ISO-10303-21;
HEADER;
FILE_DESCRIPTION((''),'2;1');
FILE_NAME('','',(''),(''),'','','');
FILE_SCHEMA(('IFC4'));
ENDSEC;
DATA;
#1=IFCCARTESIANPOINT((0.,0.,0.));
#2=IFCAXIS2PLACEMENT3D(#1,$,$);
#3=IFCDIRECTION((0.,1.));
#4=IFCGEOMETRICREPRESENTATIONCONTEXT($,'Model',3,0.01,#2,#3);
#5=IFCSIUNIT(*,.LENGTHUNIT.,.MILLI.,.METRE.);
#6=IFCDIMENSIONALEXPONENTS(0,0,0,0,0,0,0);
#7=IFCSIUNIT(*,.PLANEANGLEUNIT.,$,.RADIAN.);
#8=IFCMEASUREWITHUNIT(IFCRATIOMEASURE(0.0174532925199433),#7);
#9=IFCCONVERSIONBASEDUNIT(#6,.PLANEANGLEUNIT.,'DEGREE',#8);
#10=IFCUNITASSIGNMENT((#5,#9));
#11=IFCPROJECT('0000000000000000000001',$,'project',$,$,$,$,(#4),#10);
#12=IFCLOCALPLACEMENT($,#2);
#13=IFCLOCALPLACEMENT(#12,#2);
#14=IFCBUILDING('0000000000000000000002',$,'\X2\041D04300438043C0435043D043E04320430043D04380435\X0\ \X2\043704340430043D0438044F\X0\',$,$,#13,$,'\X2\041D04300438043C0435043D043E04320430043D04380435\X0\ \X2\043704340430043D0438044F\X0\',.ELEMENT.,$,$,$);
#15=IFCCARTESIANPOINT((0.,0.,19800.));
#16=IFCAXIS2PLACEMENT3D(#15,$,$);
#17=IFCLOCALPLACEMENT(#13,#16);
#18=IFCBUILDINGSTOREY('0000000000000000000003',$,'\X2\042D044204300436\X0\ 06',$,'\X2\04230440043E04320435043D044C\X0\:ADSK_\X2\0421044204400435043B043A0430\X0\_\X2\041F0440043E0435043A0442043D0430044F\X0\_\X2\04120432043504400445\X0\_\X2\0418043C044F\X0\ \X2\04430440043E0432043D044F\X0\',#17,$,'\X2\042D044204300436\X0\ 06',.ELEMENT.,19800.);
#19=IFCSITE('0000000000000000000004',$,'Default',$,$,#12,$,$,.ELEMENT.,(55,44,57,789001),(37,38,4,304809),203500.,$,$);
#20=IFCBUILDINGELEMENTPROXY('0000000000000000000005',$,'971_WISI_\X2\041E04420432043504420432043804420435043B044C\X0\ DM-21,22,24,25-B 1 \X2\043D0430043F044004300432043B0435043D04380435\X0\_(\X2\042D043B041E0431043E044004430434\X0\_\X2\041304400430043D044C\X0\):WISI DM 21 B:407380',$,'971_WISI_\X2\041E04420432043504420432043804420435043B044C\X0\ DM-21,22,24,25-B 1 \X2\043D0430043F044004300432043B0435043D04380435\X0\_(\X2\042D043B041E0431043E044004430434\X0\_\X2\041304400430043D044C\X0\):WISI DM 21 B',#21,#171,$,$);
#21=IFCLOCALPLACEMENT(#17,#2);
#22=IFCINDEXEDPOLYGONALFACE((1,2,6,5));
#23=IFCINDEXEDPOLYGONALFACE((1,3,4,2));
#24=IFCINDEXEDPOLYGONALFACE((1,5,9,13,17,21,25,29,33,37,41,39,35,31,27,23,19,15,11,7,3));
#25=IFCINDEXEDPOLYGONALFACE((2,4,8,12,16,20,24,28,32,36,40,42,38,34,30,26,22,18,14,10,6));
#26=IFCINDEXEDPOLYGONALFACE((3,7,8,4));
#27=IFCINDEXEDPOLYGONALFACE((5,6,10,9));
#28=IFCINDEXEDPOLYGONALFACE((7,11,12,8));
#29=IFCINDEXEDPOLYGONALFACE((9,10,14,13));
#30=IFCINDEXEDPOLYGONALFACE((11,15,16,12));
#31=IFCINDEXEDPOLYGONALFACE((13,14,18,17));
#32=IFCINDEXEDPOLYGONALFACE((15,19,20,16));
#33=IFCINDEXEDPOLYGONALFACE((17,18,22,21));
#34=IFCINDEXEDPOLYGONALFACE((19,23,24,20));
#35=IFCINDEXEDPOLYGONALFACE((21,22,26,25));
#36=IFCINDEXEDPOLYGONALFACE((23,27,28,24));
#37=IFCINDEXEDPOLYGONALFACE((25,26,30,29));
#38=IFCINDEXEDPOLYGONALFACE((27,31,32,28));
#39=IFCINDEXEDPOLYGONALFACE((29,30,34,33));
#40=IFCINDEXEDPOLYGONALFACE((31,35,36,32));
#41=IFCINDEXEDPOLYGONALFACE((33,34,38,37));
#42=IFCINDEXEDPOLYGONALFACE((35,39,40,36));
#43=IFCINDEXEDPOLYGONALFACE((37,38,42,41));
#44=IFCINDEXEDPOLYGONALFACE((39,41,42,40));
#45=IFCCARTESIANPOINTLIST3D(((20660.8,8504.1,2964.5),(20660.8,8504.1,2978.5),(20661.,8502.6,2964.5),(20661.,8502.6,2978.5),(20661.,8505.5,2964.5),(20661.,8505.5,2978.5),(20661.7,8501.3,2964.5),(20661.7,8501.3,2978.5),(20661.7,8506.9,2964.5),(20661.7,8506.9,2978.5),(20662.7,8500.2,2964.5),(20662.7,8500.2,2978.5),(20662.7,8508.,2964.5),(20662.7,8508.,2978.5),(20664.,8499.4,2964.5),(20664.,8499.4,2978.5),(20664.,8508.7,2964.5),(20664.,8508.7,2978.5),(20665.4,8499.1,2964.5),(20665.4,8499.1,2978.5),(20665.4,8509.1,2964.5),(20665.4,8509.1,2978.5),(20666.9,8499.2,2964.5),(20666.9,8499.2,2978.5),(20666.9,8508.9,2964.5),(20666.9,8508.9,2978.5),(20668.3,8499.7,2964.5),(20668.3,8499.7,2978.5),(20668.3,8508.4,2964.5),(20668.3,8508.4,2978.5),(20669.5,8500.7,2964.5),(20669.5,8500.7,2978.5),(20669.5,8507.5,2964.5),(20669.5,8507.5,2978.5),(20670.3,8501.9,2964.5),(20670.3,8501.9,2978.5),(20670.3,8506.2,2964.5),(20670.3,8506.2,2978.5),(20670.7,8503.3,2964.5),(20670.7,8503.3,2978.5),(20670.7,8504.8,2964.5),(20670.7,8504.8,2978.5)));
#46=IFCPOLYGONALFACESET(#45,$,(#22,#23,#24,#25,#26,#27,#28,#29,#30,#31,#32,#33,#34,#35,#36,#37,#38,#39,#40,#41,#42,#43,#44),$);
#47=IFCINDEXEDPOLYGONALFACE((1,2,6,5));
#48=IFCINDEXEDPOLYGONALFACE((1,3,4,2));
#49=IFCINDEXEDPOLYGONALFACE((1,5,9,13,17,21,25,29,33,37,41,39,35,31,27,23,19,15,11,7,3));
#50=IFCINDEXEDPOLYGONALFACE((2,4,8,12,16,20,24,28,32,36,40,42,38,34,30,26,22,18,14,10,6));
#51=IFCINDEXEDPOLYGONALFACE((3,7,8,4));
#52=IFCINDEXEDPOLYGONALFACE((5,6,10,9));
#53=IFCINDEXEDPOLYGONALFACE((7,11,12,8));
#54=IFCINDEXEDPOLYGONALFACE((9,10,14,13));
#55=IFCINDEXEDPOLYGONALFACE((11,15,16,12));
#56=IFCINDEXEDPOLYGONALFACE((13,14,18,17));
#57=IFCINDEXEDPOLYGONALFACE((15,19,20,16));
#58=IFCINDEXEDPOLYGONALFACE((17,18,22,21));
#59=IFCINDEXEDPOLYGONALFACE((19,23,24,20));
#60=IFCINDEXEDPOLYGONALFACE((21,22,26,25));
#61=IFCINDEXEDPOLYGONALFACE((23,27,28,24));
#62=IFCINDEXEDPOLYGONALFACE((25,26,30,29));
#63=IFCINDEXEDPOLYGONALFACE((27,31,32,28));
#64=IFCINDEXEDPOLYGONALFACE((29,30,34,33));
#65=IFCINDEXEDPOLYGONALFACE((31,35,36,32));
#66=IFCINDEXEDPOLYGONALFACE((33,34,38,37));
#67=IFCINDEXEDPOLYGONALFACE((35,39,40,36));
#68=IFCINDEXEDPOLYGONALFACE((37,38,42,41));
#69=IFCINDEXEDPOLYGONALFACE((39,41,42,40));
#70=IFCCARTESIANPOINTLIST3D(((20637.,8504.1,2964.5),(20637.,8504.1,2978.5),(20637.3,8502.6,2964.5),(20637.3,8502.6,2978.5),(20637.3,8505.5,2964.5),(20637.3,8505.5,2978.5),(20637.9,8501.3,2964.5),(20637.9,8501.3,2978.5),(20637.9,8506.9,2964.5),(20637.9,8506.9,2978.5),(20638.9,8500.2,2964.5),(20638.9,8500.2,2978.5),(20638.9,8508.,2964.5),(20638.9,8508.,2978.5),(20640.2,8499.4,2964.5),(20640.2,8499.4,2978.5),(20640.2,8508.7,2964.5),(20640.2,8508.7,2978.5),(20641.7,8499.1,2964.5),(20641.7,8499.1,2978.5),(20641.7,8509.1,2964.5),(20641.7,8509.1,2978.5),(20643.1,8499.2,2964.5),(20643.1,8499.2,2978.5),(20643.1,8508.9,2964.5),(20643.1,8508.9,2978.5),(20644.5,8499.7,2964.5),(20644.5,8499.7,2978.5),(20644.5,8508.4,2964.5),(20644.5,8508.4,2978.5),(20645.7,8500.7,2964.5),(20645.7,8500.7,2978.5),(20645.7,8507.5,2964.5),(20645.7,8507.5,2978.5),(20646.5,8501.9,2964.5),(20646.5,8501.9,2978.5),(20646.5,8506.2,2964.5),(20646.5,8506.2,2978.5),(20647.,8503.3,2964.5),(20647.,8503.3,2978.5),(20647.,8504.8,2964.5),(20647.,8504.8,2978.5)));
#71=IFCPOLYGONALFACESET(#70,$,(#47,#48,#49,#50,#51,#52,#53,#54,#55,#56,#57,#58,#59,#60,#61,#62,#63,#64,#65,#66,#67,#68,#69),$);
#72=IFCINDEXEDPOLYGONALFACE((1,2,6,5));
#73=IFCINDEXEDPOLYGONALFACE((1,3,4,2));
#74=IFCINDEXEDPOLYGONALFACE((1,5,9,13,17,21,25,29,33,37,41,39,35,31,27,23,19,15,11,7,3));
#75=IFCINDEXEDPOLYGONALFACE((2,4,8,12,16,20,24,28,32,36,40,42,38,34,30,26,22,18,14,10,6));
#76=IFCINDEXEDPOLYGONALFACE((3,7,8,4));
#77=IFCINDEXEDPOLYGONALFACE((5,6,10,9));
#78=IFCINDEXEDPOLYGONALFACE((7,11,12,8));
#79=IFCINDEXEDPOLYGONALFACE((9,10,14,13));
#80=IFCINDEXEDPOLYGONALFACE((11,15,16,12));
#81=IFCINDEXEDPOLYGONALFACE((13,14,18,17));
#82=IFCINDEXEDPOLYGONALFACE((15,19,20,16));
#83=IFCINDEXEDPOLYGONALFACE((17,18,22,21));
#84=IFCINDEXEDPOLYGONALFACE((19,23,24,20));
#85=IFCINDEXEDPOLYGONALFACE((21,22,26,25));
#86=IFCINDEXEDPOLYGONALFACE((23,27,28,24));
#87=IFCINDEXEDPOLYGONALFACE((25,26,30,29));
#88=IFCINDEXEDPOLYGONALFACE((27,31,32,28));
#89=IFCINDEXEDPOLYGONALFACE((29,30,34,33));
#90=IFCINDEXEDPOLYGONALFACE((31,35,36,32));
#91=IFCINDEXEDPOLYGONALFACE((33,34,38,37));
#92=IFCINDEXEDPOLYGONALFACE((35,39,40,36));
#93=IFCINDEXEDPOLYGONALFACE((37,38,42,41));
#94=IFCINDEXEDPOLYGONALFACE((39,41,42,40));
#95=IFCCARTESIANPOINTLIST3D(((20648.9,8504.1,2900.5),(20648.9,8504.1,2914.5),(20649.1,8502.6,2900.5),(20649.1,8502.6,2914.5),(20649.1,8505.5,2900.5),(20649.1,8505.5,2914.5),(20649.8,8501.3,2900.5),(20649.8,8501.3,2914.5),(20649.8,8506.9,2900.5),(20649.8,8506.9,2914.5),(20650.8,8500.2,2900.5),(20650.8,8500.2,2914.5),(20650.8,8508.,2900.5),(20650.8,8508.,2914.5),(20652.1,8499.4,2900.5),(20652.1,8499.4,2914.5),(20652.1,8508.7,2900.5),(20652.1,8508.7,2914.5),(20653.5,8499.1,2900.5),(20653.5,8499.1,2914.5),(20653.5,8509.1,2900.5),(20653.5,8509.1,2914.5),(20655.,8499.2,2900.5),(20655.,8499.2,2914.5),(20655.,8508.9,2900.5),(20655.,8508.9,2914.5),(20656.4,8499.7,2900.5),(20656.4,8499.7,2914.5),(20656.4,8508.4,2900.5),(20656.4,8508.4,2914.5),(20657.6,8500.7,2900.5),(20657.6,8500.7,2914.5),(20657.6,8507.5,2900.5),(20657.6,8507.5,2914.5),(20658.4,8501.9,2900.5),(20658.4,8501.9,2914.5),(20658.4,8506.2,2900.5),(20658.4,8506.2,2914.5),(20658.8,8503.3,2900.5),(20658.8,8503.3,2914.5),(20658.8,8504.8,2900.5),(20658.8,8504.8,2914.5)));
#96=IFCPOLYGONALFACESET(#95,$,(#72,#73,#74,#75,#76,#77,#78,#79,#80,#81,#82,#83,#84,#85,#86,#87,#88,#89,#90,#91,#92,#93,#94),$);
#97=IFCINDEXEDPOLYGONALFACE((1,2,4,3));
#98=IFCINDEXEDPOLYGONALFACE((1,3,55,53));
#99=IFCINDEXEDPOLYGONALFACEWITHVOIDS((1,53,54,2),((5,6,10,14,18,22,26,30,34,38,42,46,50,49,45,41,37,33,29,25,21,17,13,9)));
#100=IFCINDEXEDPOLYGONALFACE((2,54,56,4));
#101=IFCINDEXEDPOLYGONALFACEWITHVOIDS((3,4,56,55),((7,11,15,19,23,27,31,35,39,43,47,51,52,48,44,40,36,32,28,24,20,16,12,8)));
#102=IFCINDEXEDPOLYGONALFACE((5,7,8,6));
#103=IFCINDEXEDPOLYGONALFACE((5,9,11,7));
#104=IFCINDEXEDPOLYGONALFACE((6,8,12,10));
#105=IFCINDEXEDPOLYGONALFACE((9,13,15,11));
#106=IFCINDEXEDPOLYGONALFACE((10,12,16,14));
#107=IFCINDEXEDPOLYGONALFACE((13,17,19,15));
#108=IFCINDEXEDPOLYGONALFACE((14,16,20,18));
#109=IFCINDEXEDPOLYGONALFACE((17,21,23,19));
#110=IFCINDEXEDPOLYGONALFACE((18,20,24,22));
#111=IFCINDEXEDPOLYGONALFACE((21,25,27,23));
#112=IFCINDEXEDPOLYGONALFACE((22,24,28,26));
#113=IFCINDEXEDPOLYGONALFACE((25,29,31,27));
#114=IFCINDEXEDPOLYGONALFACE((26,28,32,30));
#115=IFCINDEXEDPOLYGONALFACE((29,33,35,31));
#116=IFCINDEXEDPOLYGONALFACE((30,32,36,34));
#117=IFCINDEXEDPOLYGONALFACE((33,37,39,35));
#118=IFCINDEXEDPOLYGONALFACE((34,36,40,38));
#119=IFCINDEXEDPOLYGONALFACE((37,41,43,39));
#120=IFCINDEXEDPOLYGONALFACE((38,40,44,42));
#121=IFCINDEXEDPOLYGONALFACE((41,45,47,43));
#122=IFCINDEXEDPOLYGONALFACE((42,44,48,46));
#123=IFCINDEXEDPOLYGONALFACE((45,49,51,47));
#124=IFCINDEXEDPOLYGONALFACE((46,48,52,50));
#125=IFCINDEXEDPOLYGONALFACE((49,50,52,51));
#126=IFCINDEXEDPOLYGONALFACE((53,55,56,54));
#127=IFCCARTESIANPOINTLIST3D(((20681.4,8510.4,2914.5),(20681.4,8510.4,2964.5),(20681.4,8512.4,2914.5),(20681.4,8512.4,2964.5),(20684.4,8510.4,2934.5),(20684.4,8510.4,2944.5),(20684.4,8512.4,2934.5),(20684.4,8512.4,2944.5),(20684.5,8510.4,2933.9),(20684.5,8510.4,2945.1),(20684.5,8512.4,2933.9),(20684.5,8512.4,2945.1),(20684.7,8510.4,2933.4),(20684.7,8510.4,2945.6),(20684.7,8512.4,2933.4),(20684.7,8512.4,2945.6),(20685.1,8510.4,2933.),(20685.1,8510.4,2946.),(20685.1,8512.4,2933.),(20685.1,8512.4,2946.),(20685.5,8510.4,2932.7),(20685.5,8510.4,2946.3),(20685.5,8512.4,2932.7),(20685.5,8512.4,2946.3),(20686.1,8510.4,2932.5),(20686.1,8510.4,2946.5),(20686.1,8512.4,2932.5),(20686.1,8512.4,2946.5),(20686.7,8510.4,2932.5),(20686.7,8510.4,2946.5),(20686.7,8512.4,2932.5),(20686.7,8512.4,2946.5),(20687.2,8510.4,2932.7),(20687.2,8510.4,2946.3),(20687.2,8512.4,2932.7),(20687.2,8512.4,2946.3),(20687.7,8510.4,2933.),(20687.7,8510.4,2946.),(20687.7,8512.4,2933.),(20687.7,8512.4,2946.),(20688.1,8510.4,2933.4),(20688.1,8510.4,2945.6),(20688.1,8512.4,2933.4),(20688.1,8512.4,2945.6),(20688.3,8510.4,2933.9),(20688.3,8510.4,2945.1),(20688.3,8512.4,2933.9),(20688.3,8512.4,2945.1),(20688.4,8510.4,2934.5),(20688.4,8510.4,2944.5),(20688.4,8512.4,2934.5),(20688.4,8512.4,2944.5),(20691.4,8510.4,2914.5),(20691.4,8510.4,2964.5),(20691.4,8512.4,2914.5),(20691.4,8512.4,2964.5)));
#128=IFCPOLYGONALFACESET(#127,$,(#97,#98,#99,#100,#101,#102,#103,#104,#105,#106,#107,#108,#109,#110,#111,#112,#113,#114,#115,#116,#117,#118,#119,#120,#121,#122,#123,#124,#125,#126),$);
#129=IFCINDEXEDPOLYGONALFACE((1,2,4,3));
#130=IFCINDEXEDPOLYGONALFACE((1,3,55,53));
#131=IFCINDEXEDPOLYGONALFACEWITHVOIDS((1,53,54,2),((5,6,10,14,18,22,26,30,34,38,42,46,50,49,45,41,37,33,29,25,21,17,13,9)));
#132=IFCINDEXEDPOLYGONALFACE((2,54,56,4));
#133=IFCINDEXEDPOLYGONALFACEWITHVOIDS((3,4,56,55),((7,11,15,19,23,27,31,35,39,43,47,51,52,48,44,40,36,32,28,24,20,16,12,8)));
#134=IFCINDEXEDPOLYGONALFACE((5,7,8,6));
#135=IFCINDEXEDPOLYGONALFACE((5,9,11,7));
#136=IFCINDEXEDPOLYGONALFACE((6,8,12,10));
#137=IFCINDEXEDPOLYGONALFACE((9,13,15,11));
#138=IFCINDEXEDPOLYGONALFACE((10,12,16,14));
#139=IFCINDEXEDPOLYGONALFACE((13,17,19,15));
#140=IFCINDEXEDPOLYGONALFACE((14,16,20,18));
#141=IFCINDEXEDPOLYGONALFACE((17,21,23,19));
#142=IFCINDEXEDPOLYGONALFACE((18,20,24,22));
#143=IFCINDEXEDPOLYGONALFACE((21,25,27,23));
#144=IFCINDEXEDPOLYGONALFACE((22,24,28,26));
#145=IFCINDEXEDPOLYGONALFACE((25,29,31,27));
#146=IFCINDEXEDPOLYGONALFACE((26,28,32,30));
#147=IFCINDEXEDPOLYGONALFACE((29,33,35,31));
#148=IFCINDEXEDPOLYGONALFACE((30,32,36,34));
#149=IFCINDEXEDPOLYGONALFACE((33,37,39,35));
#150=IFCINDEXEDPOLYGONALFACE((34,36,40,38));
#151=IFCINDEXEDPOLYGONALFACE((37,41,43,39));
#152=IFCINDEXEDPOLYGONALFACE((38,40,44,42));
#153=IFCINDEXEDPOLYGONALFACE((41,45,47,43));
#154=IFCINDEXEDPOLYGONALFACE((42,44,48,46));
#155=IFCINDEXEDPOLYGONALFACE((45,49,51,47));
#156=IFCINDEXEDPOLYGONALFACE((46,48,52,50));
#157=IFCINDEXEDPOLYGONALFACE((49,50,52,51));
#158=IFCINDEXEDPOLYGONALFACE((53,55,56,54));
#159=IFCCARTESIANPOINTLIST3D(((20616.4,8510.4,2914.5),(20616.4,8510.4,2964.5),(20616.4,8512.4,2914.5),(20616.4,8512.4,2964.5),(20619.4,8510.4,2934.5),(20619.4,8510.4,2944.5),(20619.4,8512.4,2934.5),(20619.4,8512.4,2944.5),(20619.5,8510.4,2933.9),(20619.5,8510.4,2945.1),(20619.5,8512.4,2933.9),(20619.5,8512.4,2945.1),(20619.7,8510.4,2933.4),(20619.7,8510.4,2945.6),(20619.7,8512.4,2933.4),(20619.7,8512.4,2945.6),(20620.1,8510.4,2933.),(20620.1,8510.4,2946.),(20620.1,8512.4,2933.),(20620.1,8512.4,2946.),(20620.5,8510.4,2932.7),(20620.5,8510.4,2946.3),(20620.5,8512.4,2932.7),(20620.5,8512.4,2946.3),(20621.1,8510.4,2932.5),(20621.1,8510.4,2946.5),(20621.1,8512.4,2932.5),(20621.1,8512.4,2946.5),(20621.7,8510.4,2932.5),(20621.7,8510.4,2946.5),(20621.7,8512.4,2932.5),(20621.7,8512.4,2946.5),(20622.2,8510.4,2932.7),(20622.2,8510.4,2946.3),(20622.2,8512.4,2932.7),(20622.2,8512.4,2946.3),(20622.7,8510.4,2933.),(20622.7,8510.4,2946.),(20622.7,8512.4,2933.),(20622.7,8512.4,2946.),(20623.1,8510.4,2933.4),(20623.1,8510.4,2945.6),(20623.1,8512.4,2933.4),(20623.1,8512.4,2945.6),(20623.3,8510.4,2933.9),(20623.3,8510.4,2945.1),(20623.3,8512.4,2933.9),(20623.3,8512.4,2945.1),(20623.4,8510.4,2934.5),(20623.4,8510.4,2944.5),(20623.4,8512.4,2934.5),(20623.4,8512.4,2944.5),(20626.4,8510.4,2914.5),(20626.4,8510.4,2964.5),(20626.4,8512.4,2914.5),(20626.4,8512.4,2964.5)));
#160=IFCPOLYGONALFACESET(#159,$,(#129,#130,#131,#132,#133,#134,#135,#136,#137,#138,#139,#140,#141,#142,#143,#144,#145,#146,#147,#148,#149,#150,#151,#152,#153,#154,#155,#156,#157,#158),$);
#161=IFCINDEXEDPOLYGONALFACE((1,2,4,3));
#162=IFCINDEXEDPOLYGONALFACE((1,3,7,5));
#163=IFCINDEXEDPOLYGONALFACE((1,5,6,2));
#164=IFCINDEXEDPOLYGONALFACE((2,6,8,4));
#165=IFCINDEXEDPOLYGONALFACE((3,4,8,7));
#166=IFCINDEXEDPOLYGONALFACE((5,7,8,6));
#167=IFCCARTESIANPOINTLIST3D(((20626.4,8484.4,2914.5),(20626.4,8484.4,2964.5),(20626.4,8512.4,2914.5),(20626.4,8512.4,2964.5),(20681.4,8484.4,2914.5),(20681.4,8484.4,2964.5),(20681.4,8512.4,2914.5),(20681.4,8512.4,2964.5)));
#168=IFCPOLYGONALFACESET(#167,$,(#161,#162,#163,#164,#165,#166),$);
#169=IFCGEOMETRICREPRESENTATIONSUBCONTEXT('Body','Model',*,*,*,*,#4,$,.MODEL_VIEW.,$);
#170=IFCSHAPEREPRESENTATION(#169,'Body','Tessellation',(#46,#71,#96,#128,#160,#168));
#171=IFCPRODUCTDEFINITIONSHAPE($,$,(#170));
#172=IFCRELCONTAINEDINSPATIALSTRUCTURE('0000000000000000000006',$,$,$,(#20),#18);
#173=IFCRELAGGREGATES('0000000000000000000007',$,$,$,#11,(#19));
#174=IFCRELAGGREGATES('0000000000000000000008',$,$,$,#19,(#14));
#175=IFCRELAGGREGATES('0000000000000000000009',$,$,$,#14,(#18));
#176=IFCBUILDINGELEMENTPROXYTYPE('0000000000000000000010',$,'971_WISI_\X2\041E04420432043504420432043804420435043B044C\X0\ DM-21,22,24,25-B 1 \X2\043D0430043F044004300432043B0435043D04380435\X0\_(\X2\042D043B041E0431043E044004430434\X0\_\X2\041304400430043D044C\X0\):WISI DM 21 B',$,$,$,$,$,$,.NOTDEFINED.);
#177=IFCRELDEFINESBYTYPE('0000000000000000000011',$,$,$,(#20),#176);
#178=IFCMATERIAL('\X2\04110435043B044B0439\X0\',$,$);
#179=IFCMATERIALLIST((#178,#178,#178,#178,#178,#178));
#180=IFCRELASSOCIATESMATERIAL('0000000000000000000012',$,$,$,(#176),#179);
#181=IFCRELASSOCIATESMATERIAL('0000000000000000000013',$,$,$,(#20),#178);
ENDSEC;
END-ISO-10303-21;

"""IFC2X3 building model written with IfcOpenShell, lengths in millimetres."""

from ifc_helpers import new_model, entity, si_unit, converted_unit, direction, frame, frame_2d, origin, place, context, subcontext, project, spatial, polyline, circle_curve, parameter, trimmed, segment, composite_curve, rectangle, circle, outline, extrude, source, transform, mapped, material, material_list, type_object, type_shapes, element, save


model = new_model("IFC2X3")

# Units and contexts
model_context = context("Model", 3, precision=0.01, world=origin(), true_north=direction((0.0, 1.0)))
body_context = subcontext(model_context, "Body", "Model", "MODEL_VIEW")
ifc_project = project(units=[si_unit("LENGTHUNIT", "METRE", prefix="MILLI"), converted_unit("PLANEANGLEUNIT", "DEGREE", entity("IfcRatioMeasure", 0.0174532925199433), si_unit("PLANEANGLEUNIT", "RADIAN"), dimensions=[0, 0, 0, 0, 0, 0, 0])], contexts=[model_context])

# Site, building, storey
site_placement = place(None, frame((0.0, 0.0, 0.0)))
site = spatial("IfcSite", under=ifc_project, at=site_placement, Name="Default", CompositionType="ELEMENT", RefLatitude=(55, 44, 57, 789001), RefLongitude=(37, 38, 4, 304809), RefElevation=203500.0)
building_placement = place(site_placement, origin())
building = spatial("IfcBuilding", under=site, at=building_placement, Name="Наименование здания", LongName="Наименование здания", CompositionType="ELEMENT")
storey_placement = place(building_placement, frame((0.0, 0.0, 19800.0)))
storey = spatial("IfcBuildingStorey", under=building, at=storey_placement, Name="Этаж 06", ObjectType="Уровень:ADSK_Стрелка_Проектная_Вверх_Имя уровня", LongName="Этаж 06", CompositionType="ELEMENT", Elevation=19800.0)

# Building element proxy
ifc_material_1 = material(Name="Белый")
ifc_material_list_1 = material_list([ifc_material_1, ifc_material_1, ifc_material_1, ifc_material_1, ifc_material_1, ifc_material_1])
building_element_proxy_type_1 = type_object("IfcBuildingElementProxyType", Name="971_WISI_Ответвитель DM-21,22,24,25-B 1 направление_(ЭлОборуд_Грань):WISI DM 21 B", PredefinedType="NOTDEFINED", material=ifc_material_list_1)
shared_shape_1 = source(origin(), body_context, "Body", "SweptSolid", [
    extrude(circle(Radius=5.0, at=frame_2d((0.0, 0.0), x_axis=(1.0, 0.0))), frame((11.9, 25.0, 8.4), z_axis=(0.0, 1.0, 0.0), x_axis=(-1.0, 0.0, 0.0)), (0.0, 0.0, 1.0), 14.0),
    extrude(circle(Radius=5.0, at=frame_2d((0.0, 0.0), x_axis=(1.0, 0.0))), frame((-11.8, 25.0, 8.4), z_axis=(0.0, 1.0, 0.0), x_axis=(-1.0, 0.0, 0.0)), (0.0, 0.0, 1.0), 14.0),
    extrude(circle(Radius=5.0, at=frame_2d((0.0, 0.0), x_axis=(1.0, 0.0))), frame((0.0, -39.0, 8.4), z_axis=(0.0, 1.0, 0.0), x_axis=(-1.0, 0.0, 0.0)), (0.0, 0.0, 1.0), 14.0),
    extrude(outline(polyline([(-5.0, -25.0), (5.0, -25.0), (5.0, 25.0), (-5.0, 25.0), (-5.0, -25.0)]), holes=[composite_curve([segment(polyline([(2.0, 5.0), (2.0, -5.0)]), True, "CONTINUOUS"), segment(trimmed(circle_curve(frame_2d((0.0, -5.0), x_axis=(-1.0, 0.0)), 2.0), [parameter(0.0)], [parameter(180.0)], True, "PARAMETER"), False, "CONTINUOUS"), segment(polyline([(-2.0, -5.0), (-2.0, 5.0)]), True, "CONTINUOUS"), segment(trimmed(circle_curve(frame_2d((0.0, 5.0), x_axis=(-1.0, 0.0)), 2.0), [parameter(180.0)], [parameter(0.0)], True, "PARAMETER"), False, "CONTINUOUS")], self_intersect=False)]), frame((32.5, 0.0, 0.0), z_axis=(0.0, 0.0, 1.0), x_axis=(-1.0, 0.0, 0.0)), (0.0, 0.0, 1.0), 2.0),
    extrude(outline(polyline([(-5.0, -25.0), (5.0, -25.0), (5.0, 25.0), (-5.0, 25.0), (-5.0, -25.0)]), holes=[composite_curve([segment(polyline([(-2.0, -5.0), (-2.0, 5.0)]), True, "CONTINUOUS"), segment(trimmed(circle_curve(frame_2d((0.0, 5.0), x_axis=(-1.0, 0.0)), 2.0), [parameter(180.0)], [parameter(0.0)], True, "PARAMETER"), False, "CONTINUOUS"), segment(polyline([(2.0, 5.0), (2.0, -5.0)]), True, "CONTINUOUS"), segment(trimmed(circle_curve(frame_2d((0.0, -5.0), x_axis=(-1.0, 0.0)), 2.0), [parameter(0.0)], [parameter(180.0)], True, "PARAMETER"), False, "CONTINUOUS")], self_intersect=False)]), frame((-32.5, 0.0, 0.0), z_axis=(0.0, 0.0, 1.0), x_axis=(-1.0, 0.0, 0.0)), (0.0, 0.0, 1.0), 2.0),
    extrude(rectangle(XDim=55.0, YDim=50.0, at=frame_2d((0.0, 0.0), x_axis=(1.0, 0.0))), frame((0.0, 0.0, 0.0), z_axis=(0.0, 0.0, 1.0), x_axis=(-1.0, 0.0, 0.0)), (0.0, 0.0, 1.0), 28.0),
])
type_shapes(building_element_proxy_type_1, [shared_shape_1])
for number, where, z_axis, x_axis, name in (
    (1, (20653.9, 8512.4, 2939.5), (0.0, -1.0, 0.0), (1.0, 0.0, 0.0), "971_WISI_Ответвитель DM-21,22,24,25-B 1 направление_(ЭлОборуд_Грань):WISI DM 21 B:407380"),
):
    element("IfcBuildingElementProxy", number, at=place(storey_placement, frame(where, z_axis=z_axis, x_axis=x_axis)), inside=storey, type_object=building_element_proxy_type_1, material=ifc_material_1, Name=name, ObjectType="971_WISI_Ответвитель DM-21,22,24,25-B 1 направление_(ЭлОборуд_Грань):WISI DM 21 B", context=body_context, shape_type="MappedRepresentation", body=[
        mapped(shared_shape_1, transform((0.0, 0.0, 0.0), scale=1.0)),
    ])

save(model, "model.ifc")
